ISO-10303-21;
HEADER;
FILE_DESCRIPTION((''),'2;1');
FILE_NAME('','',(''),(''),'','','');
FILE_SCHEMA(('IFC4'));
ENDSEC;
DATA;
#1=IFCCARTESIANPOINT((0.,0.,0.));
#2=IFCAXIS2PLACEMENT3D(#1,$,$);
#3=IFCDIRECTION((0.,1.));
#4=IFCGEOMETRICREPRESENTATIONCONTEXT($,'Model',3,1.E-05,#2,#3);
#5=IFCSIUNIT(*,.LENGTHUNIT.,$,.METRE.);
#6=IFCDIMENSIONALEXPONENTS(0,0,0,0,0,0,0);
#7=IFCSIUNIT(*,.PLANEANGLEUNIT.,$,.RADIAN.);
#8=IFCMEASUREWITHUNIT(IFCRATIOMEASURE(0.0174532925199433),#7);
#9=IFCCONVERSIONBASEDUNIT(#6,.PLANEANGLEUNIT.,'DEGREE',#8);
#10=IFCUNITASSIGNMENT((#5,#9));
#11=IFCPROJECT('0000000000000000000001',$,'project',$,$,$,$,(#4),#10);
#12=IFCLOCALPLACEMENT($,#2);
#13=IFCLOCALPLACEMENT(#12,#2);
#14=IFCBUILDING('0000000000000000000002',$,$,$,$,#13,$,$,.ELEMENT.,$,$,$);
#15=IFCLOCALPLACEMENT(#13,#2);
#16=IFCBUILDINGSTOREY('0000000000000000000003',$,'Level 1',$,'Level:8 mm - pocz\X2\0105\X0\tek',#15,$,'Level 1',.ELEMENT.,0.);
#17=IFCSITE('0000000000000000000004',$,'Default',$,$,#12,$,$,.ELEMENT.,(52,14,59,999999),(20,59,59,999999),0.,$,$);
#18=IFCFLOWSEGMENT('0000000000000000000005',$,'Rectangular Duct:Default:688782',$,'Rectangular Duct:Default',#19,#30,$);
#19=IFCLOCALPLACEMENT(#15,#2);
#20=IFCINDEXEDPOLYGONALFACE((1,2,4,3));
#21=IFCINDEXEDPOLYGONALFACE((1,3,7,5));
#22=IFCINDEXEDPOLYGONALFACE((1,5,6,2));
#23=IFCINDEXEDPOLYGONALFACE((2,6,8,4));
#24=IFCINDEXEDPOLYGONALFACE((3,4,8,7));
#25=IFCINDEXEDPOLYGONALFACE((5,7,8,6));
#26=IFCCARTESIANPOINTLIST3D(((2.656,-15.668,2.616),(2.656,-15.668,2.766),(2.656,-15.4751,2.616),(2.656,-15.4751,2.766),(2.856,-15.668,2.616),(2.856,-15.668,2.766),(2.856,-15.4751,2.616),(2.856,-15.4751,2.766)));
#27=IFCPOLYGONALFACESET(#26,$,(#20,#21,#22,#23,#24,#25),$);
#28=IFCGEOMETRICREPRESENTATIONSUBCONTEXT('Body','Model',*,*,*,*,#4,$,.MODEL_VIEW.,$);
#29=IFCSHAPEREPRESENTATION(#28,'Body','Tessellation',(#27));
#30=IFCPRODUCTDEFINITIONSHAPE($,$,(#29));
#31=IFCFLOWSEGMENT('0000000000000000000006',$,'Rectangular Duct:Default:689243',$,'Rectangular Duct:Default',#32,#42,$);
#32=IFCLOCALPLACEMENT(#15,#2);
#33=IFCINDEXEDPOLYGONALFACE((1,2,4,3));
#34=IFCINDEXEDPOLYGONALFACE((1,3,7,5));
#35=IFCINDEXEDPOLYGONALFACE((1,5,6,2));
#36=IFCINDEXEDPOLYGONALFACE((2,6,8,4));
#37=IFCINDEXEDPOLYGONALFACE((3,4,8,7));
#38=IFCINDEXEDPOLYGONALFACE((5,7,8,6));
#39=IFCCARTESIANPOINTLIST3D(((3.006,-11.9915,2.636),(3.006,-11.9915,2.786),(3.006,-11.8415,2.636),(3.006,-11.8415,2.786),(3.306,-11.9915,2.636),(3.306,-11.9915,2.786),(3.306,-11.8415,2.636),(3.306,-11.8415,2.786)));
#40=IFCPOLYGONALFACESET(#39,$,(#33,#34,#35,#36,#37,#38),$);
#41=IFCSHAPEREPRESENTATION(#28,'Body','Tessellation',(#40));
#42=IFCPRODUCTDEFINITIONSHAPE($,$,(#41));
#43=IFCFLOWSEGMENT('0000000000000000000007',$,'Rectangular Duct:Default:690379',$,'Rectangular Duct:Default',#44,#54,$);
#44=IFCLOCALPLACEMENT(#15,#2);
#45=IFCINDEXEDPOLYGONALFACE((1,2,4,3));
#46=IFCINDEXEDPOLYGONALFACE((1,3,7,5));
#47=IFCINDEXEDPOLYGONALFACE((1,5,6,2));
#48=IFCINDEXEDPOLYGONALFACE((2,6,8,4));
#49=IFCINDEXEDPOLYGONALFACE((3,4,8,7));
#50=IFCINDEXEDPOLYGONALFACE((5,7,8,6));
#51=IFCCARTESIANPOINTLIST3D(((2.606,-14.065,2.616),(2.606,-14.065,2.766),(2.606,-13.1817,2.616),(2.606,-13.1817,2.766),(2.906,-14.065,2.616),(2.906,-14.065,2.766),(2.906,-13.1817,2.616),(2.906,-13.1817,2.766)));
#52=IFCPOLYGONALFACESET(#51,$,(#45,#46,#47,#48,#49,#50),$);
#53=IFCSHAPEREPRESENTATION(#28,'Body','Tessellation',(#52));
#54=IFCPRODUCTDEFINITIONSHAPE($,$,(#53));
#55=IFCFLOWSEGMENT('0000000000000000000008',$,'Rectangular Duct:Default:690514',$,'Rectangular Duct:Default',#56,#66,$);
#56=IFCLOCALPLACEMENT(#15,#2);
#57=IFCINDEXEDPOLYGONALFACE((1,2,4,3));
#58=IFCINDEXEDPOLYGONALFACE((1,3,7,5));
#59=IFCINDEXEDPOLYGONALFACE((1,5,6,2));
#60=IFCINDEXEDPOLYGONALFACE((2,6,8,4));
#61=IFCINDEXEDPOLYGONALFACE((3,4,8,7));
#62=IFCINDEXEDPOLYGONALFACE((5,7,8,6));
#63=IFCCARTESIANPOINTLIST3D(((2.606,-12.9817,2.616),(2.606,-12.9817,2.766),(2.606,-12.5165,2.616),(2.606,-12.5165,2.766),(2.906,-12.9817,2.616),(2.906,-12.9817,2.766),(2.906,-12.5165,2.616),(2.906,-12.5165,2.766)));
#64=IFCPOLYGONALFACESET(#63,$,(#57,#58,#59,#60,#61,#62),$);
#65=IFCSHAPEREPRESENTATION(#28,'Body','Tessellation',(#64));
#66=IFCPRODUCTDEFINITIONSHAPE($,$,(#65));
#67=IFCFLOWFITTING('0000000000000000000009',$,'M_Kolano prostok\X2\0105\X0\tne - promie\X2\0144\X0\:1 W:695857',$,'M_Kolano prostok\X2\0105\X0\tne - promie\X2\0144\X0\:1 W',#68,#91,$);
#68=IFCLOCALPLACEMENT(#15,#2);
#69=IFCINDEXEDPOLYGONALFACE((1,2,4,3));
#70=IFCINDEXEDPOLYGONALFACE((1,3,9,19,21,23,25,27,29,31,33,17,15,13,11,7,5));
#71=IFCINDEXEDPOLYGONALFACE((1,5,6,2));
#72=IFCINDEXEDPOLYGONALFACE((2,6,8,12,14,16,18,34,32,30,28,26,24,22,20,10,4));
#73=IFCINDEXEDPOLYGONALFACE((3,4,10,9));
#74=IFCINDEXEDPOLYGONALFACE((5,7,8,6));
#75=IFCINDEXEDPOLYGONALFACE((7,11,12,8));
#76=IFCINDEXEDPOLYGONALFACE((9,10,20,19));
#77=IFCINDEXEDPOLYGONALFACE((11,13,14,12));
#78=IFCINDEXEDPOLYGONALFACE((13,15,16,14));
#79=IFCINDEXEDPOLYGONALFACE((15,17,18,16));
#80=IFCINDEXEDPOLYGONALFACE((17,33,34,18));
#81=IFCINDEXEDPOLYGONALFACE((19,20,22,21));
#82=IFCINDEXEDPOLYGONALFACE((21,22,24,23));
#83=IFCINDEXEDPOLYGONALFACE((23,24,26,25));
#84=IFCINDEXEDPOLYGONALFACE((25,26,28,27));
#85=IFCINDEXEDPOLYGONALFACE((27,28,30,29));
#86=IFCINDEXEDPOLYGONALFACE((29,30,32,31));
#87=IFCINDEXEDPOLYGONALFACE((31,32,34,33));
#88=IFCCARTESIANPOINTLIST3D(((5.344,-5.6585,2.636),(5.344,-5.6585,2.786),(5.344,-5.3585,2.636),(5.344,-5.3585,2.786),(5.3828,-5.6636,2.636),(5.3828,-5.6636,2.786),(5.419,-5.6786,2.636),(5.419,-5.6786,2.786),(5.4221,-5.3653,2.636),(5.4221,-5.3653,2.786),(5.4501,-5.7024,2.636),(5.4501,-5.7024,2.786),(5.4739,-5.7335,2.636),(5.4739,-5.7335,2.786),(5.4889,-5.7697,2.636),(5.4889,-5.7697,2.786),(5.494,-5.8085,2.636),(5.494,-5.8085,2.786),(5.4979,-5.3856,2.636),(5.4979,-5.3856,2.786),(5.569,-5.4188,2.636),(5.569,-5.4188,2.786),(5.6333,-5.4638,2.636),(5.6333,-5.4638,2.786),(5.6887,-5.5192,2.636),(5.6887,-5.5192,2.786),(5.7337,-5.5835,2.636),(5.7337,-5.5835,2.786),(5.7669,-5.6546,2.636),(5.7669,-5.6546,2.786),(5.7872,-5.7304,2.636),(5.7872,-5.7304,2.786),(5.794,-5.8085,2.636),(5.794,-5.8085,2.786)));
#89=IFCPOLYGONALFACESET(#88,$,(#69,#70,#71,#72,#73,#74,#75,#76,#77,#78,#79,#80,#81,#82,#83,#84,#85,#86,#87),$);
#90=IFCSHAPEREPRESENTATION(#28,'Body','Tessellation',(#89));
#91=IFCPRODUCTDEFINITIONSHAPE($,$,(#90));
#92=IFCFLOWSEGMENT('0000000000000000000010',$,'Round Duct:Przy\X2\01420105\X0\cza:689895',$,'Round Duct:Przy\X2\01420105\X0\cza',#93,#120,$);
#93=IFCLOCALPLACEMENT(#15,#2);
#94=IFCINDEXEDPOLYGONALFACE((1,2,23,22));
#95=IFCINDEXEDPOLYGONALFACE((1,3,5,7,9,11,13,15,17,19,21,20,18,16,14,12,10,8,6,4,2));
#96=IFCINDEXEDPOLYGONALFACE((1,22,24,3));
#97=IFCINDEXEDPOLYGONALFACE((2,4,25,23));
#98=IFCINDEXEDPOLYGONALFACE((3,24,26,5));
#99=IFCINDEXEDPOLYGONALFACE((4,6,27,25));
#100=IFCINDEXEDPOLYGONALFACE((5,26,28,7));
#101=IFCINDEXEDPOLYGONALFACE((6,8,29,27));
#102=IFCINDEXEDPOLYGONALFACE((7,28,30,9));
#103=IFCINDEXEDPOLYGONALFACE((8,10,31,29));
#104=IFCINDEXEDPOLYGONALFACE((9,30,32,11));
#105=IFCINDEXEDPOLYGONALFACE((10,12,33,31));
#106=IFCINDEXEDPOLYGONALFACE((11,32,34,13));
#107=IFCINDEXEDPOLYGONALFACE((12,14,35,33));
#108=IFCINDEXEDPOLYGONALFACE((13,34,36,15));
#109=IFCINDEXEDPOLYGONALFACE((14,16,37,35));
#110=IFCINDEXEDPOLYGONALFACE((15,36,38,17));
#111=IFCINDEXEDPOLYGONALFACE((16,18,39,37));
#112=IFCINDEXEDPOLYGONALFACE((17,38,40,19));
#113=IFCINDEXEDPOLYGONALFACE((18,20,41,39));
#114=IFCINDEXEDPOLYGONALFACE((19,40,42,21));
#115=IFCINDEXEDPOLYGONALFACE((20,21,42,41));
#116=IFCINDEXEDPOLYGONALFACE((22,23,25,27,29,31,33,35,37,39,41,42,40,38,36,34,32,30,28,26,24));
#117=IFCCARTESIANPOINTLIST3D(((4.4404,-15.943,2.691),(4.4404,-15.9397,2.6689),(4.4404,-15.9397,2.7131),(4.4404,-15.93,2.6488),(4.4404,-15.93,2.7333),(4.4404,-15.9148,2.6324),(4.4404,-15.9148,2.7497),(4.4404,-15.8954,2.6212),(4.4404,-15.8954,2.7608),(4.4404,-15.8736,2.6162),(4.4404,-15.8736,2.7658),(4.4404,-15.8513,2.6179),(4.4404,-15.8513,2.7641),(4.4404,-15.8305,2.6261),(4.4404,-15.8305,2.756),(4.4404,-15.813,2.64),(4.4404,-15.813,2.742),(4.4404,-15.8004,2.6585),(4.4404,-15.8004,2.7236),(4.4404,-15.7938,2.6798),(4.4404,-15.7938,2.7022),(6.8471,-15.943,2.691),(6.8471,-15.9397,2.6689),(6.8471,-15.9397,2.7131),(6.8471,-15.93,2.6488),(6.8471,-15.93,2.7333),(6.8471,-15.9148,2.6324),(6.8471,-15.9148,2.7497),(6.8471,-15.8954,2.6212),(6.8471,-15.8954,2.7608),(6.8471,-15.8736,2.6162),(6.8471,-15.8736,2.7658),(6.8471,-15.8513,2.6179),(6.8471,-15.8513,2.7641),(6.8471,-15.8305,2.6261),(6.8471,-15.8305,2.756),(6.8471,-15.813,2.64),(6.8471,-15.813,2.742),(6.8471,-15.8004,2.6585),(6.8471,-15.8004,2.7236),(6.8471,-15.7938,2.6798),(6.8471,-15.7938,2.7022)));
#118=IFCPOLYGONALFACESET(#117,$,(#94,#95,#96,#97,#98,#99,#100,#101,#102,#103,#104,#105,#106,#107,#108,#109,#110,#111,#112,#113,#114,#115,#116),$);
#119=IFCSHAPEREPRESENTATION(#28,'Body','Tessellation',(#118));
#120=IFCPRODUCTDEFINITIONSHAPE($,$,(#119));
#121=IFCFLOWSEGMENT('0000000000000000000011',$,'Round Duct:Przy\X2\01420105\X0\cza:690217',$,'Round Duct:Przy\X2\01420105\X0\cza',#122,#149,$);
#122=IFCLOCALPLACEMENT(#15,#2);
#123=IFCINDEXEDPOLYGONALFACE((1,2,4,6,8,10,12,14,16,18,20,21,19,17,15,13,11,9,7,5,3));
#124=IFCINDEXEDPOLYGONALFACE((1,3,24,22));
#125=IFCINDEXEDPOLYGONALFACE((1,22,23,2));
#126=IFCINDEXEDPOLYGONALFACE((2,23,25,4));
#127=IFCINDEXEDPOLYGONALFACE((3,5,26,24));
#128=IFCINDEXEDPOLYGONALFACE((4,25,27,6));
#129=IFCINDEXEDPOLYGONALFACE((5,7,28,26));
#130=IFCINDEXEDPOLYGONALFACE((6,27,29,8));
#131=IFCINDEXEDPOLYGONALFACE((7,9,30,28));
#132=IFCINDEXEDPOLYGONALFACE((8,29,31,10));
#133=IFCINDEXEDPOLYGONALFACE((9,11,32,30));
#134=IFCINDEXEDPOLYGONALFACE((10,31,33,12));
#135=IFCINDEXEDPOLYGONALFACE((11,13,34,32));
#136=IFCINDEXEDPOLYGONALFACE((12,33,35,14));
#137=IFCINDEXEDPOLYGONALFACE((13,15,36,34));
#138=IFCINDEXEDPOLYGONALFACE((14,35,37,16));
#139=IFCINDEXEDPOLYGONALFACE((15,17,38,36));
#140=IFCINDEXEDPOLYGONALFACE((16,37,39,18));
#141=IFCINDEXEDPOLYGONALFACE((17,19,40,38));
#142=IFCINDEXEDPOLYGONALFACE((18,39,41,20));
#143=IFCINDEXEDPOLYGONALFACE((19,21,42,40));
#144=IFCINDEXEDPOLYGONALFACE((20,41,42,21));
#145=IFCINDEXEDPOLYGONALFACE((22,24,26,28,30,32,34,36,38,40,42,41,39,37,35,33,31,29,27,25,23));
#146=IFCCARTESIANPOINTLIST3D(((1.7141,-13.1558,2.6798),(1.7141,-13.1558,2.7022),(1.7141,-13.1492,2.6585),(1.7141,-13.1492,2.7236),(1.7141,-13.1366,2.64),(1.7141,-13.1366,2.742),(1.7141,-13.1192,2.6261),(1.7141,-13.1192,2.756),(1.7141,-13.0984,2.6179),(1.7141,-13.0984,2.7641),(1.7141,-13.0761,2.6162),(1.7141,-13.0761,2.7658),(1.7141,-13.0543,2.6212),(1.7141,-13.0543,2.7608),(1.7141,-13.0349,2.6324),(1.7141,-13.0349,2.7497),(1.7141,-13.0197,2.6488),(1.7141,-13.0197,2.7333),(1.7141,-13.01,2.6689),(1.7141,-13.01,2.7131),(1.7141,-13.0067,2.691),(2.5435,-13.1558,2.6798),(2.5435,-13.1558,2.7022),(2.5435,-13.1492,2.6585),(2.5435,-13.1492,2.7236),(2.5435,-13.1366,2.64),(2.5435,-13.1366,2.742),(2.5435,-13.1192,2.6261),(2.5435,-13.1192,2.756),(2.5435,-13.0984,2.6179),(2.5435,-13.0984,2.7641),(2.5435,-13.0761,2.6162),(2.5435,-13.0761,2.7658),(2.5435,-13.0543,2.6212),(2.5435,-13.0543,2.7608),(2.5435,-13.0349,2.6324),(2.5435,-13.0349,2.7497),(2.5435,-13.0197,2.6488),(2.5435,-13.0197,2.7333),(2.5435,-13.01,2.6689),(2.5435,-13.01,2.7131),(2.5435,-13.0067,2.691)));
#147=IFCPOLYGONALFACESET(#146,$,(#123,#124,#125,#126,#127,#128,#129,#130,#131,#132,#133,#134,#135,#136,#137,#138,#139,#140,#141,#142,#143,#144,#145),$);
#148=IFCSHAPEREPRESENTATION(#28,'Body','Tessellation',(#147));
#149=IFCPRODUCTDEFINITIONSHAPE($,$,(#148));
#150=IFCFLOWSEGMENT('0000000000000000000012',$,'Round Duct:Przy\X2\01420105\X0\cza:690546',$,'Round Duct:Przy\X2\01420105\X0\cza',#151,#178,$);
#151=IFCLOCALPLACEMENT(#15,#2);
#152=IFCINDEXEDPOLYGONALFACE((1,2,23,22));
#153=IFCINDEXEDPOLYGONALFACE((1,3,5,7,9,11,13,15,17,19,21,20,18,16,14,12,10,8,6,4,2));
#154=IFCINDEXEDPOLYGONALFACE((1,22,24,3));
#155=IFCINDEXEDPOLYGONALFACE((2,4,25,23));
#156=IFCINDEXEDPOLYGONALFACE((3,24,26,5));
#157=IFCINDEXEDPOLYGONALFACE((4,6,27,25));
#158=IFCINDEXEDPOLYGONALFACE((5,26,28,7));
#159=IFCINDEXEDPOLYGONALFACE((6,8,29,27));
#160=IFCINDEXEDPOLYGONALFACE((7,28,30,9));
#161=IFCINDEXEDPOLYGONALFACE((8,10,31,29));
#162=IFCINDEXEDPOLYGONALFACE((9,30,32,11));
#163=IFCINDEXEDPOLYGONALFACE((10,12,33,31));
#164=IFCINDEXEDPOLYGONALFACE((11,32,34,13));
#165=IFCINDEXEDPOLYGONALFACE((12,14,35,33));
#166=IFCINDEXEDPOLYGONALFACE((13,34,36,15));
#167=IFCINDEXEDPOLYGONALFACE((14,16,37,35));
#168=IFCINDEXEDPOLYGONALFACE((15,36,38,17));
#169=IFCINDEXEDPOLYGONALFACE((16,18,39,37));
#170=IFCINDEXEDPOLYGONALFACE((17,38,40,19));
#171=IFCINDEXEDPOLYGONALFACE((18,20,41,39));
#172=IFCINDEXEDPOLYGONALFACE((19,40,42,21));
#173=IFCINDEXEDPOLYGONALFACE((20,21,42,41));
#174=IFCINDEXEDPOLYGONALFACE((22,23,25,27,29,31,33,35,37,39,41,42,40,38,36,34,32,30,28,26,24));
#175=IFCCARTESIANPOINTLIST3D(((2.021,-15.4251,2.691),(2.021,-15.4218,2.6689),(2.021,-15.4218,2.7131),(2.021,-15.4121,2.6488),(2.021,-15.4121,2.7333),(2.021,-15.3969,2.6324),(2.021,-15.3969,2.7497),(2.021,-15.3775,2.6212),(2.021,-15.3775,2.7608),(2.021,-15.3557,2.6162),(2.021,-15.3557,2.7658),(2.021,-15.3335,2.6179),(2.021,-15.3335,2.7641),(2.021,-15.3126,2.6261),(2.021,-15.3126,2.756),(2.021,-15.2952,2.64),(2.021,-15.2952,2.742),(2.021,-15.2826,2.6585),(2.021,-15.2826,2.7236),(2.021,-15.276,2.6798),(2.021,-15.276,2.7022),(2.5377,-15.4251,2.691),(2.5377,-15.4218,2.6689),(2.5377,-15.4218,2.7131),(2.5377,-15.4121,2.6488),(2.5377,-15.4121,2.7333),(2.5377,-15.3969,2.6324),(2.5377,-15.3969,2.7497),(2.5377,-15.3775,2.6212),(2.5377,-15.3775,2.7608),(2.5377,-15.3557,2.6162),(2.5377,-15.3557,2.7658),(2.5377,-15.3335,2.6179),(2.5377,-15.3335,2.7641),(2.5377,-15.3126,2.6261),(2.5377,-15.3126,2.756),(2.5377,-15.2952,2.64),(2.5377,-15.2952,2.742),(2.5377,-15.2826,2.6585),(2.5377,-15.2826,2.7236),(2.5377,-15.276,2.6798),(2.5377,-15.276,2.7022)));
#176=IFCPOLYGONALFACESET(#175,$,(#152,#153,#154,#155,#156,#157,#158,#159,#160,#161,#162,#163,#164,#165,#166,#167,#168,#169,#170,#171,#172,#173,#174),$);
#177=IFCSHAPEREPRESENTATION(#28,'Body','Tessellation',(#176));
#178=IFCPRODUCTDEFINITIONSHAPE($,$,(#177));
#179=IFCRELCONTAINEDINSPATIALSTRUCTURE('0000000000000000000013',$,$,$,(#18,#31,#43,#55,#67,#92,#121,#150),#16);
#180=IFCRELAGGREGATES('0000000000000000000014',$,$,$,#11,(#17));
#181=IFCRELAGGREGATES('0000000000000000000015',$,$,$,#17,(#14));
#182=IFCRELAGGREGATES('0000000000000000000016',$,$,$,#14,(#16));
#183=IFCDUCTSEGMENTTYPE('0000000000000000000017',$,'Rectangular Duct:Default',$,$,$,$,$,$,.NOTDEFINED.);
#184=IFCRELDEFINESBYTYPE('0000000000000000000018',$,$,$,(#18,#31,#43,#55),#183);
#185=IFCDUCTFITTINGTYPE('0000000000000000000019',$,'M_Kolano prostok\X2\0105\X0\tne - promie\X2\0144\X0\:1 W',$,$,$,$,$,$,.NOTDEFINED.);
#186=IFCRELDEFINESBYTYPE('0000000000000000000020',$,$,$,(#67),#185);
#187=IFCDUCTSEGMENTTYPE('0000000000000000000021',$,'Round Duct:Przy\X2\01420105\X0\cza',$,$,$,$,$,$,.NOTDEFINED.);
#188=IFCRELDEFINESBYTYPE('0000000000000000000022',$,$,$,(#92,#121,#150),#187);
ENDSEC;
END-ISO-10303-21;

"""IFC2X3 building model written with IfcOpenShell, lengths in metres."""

from ifc_helpers import new_model, entity, si_unit, converted_unit, direction, frame, frame_2d, origin, origin_2d_with_axis, place, context, subcontext, project, spatial, polyline, circle_curve, parameter, trimmed, segment, composite_curve, rectangle, circle, outline, extrude, source, transform, mapped, type_object, type_shapes, element, save


model = new_model("IFC2X3")

# Units and contexts
model_context = context("Model", 3, precision=1e-05, world=origin(), true_north=direction((0.0, 1.0)))
body_context = subcontext(model_context, "Body", "Model", "MODEL_VIEW")
ifc_project = project(units=[si_unit("LENGTHUNIT", "METRE"), converted_unit("PLANEANGLEUNIT", "DEGREE", entity("IfcRatioMeasure", 0.0174532925199433), si_unit("PLANEANGLEUNIT", "RADIAN"), dimensions=[0, 0, 0, 0, 0, 0, 0])], contexts=[model_context])

# Site, building, storey
site_placement = place(None, origin())
site = spatial("IfcSite", under=ifc_project, at=site_placement, Name="Default", CompositionType="ELEMENT", RefLatitude=(52, 14, 59, 999999), RefLongitude=(20, 59, 59, 999999), RefElevation=0.0)
building_placement = place(site_placement, origin())
building = spatial("IfcBuilding", under=site, at=building_placement, CompositionType="ELEMENT")
storey_placement = place(building_placement, origin())
storey = spatial("IfcBuildingStorey", under=building, at=storey_placement, Name="Level 1", ObjectType="Level:8 mm - początek", LongName="Level 1", CompositionType="ELEMENT", Elevation=0.0)

# Flow segments
duct_segment_type_1 = type_object("IfcDuctSegmentType", Name="Rectangular Duct:Default", PredefinedType="NOTDEFINED")
flow_segment_1_placement = place(storey_placement, origin())
element("IfcFlowSegment", 1, at=flow_segment_1_placement, inside=storey, type_object=duct_segment_type_1, Name="Rectangular Duct:Default:688782", ObjectType="Rectangular Duct:Default", context=body_context, shape_type="SweptSolid", body=[
    extrude(rectangle(XDim=0.1929, YDim=0.2, at=frame_2d((0.0, 0.0), x_axis=(1.0, 0.0))), frame((2.756, -15.5716, 2.616), z_axis=(0.0, 0.0, 1.0), x_axis=(0.0, -1.0, 0.0)), (0.0, 0.0, 1.0), 0.15),
])
flow_segment_2_placement = place(storey_placement, origin())
element("IfcFlowSegment", 2, at=flow_segment_2_placement, inside=storey, type_object=duct_segment_type_1, Name="Rectangular Duct:Default:689243", ObjectType="Rectangular Duct:Default", context=body_context, shape_type="SweptSolid", body=[
    extrude(rectangle(XDim=0.15, YDim=0.3, at=origin_2d_with_axis()), frame((3.156, -11.9165, 2.636), z_axis=(0.0, 0.0, 1.0), x_axis=(0.0, -1.0, 0.0)), (0.0, 0.0, 1.0), 0.15),
])
flow_segment_3_placement = place(storey_placement, origin())
element("IfcFlowSegment", 3, at=flow_segment_3_placement, inside=storey, type_object=duct_segment_type_1, Name="Rectangular Duct:Default:690379", ObjectType="Rectangular Duct:Default", context=body_context, shape_type="SweptSolid", body=[
    extrude(rectangle(XDim=0.8833, YDim=0.3, at=frame_2d((0.0, 0.0), x_axis=(1.0, 0.0))), frame((2.756, -13.6233, 2.616), z_axis=(0.0, 0.0, 1.0), x_axis=(0.0, -1.0, 0.0)), (0.0, 0.0, 1.0), 0.15),
])
flow_segment_4_placement = place(storey_placement, origin())
element("IfcFlowSegment", 4, at=flow_segment_4_placement, inside=storey, type_object=duct_segment_type_1, Name="Rectangular Duct:Default:690514", ObjectType="Rectangular Duct:Default", context=body_context, shape_type="SweptSolid", body=[
    extrude(rectangle(XDim=0.4652, YDim=0.3, at=frame_2d((0.0, 0.0), x_axis=(1.0, 0.0))), frame((2.756, -12.7491, 2.616), z_axis=(0.0, 0.0, 1.0), x_axis=(0.0, -1.0, 0.0)), (0.0, 0.0, 1.0), 0.15),
])

# Flow fitting
duct_fitting_type_1 = type_object("IfcDuctFittingType", Name="M_Kolano prostokątne - promień:1 W", PredefinedType="NOTDEFINED")
shared_shape_1 = source(origin(), body_context, "Body", "SweptSolid", [
    extrude(outline(composite_curve([segment(polyline([(-0.3, -0.15), (0.0, -0.15)]), True, "CONTINUOUS"), segment(trimmed(circle_curve(frame_2d((0.15, -0.15), x_axis=(0.0, 1.0)), 0.15), [parameter(0.0)], [parameter(90.0)], True, "PARAMETER"), False, "CONTINUOUS"), segment(polyline([(0.15, 0.0), (0.15, 0.3)]), True, "CONTINUOUS"), segment(trimmed(circle_curve(frame_2d((0.15, -0.15), x_axis=(0.0, 1.0)), 0.45), [parameter(0.0)], [parameter(90.0)], True, "PARAMETER"), True, "CONTINUOUS")], self_intersect=False)), frame((-0.15, 0.15, -0.075), z_axis=(0.0, 0.0, 1.0), x_axis=(-1.0, 0.0, 0.0)), (0.0, 0.0, 1.0), 0.15),
])
type_shapes(duct_fitting_type_1, [shared_shape_1])
flow_fitting_1_placement = place(storey_placement, frame((5.644, -5.5085, 2.711), z_axis=(0.0, 0.0, 1.0), x_axis=(0.0, 1.0, 0.0)))
element("IfcFlowFitting", 5, at=flow_fitting_1_placement, inside=storey, type_object=duct_fitting_type_1, Name="M_Kolano prostokątne - promień:1 W:695857", ObjectType="M_Kolano prostokątne - promień:1 W", context=body_context, shape_type="MappedRepresentation", body=[
    mapped(shared_shape_1, transform((0.0, 0.0, 0.0), scale=1.0)),
])

# Flow segments
duct_segment_type_2 = type_object("IfcDuctSegmentType", Name="Round Duct:Przyłącza", PredefinedType="NOTDEFINED")
flow_segment_5_placement = place(storey_placement, origin())
element("IfcFlowSegment", 6, at=flow_segment_5_placement, inside=storey, type_object=duct_segment_type_2, Name="Round Duct:Przyłącza:689895", ObjectType="Round Duct:Przyłącza", context=body_context, shape_type="SweptSolid", body=[
    extrude(circle(Radius=0.075, at=origin_2d_with_axis()), frame((4.4404, -15.868, 2.691), z_axis=(1.0, 0.0, 0.0), x_axis=(0.0, -1.0, 0.0)), (0.0, 0.0, 1.0), 2.4067),
])
flow_segment_6_placement = place(storey_placement, origin())
element("IfcFlowSegment", 7, at=flow_segment_6_placement, inside=storey, type_object=duct_segment_type_2, Name="Round Duct:Przyłącza:690217", ObjectType="Round Duct:Przyłącza", context=body_context, shape_type="SweptSolid", body=[
    extrude(circle(Radius=0.075, at=frame_2d((0.0, 0.0), x_axis=(1.0, 0.0))), frame((1.7141, -13.0817, 2.691), z_axis=(1.0, 0.0, 0.0), x_axis=(0.0, 1.0, 0.0)), (0.0, 0.0, 1.0), 0.8294),
])
flow_segment_7_placement = place(storey_placement, origin())
element("IfcFlowSegment", 8, at=flow_segment_7_placement, inside=storey, type_object=duct_segment_type_2, Name="Round Duct:Przyłącza:690546", ObjectType="Round Duct:Przyłącza", context=body_context, shape_type="SweptSolid", body=[
    extrude(circle(Radius=0.075, at=origin_2d_with_axis()), frame((2.021, -15.3501, 2.691), z_axis=(1.0, 0.0, 0.0), x_axis=(0.0, -1.0, 0.0)), (0.0, 0.0, 1.0), 0.5167),
])

save(model, "model.ifc")
